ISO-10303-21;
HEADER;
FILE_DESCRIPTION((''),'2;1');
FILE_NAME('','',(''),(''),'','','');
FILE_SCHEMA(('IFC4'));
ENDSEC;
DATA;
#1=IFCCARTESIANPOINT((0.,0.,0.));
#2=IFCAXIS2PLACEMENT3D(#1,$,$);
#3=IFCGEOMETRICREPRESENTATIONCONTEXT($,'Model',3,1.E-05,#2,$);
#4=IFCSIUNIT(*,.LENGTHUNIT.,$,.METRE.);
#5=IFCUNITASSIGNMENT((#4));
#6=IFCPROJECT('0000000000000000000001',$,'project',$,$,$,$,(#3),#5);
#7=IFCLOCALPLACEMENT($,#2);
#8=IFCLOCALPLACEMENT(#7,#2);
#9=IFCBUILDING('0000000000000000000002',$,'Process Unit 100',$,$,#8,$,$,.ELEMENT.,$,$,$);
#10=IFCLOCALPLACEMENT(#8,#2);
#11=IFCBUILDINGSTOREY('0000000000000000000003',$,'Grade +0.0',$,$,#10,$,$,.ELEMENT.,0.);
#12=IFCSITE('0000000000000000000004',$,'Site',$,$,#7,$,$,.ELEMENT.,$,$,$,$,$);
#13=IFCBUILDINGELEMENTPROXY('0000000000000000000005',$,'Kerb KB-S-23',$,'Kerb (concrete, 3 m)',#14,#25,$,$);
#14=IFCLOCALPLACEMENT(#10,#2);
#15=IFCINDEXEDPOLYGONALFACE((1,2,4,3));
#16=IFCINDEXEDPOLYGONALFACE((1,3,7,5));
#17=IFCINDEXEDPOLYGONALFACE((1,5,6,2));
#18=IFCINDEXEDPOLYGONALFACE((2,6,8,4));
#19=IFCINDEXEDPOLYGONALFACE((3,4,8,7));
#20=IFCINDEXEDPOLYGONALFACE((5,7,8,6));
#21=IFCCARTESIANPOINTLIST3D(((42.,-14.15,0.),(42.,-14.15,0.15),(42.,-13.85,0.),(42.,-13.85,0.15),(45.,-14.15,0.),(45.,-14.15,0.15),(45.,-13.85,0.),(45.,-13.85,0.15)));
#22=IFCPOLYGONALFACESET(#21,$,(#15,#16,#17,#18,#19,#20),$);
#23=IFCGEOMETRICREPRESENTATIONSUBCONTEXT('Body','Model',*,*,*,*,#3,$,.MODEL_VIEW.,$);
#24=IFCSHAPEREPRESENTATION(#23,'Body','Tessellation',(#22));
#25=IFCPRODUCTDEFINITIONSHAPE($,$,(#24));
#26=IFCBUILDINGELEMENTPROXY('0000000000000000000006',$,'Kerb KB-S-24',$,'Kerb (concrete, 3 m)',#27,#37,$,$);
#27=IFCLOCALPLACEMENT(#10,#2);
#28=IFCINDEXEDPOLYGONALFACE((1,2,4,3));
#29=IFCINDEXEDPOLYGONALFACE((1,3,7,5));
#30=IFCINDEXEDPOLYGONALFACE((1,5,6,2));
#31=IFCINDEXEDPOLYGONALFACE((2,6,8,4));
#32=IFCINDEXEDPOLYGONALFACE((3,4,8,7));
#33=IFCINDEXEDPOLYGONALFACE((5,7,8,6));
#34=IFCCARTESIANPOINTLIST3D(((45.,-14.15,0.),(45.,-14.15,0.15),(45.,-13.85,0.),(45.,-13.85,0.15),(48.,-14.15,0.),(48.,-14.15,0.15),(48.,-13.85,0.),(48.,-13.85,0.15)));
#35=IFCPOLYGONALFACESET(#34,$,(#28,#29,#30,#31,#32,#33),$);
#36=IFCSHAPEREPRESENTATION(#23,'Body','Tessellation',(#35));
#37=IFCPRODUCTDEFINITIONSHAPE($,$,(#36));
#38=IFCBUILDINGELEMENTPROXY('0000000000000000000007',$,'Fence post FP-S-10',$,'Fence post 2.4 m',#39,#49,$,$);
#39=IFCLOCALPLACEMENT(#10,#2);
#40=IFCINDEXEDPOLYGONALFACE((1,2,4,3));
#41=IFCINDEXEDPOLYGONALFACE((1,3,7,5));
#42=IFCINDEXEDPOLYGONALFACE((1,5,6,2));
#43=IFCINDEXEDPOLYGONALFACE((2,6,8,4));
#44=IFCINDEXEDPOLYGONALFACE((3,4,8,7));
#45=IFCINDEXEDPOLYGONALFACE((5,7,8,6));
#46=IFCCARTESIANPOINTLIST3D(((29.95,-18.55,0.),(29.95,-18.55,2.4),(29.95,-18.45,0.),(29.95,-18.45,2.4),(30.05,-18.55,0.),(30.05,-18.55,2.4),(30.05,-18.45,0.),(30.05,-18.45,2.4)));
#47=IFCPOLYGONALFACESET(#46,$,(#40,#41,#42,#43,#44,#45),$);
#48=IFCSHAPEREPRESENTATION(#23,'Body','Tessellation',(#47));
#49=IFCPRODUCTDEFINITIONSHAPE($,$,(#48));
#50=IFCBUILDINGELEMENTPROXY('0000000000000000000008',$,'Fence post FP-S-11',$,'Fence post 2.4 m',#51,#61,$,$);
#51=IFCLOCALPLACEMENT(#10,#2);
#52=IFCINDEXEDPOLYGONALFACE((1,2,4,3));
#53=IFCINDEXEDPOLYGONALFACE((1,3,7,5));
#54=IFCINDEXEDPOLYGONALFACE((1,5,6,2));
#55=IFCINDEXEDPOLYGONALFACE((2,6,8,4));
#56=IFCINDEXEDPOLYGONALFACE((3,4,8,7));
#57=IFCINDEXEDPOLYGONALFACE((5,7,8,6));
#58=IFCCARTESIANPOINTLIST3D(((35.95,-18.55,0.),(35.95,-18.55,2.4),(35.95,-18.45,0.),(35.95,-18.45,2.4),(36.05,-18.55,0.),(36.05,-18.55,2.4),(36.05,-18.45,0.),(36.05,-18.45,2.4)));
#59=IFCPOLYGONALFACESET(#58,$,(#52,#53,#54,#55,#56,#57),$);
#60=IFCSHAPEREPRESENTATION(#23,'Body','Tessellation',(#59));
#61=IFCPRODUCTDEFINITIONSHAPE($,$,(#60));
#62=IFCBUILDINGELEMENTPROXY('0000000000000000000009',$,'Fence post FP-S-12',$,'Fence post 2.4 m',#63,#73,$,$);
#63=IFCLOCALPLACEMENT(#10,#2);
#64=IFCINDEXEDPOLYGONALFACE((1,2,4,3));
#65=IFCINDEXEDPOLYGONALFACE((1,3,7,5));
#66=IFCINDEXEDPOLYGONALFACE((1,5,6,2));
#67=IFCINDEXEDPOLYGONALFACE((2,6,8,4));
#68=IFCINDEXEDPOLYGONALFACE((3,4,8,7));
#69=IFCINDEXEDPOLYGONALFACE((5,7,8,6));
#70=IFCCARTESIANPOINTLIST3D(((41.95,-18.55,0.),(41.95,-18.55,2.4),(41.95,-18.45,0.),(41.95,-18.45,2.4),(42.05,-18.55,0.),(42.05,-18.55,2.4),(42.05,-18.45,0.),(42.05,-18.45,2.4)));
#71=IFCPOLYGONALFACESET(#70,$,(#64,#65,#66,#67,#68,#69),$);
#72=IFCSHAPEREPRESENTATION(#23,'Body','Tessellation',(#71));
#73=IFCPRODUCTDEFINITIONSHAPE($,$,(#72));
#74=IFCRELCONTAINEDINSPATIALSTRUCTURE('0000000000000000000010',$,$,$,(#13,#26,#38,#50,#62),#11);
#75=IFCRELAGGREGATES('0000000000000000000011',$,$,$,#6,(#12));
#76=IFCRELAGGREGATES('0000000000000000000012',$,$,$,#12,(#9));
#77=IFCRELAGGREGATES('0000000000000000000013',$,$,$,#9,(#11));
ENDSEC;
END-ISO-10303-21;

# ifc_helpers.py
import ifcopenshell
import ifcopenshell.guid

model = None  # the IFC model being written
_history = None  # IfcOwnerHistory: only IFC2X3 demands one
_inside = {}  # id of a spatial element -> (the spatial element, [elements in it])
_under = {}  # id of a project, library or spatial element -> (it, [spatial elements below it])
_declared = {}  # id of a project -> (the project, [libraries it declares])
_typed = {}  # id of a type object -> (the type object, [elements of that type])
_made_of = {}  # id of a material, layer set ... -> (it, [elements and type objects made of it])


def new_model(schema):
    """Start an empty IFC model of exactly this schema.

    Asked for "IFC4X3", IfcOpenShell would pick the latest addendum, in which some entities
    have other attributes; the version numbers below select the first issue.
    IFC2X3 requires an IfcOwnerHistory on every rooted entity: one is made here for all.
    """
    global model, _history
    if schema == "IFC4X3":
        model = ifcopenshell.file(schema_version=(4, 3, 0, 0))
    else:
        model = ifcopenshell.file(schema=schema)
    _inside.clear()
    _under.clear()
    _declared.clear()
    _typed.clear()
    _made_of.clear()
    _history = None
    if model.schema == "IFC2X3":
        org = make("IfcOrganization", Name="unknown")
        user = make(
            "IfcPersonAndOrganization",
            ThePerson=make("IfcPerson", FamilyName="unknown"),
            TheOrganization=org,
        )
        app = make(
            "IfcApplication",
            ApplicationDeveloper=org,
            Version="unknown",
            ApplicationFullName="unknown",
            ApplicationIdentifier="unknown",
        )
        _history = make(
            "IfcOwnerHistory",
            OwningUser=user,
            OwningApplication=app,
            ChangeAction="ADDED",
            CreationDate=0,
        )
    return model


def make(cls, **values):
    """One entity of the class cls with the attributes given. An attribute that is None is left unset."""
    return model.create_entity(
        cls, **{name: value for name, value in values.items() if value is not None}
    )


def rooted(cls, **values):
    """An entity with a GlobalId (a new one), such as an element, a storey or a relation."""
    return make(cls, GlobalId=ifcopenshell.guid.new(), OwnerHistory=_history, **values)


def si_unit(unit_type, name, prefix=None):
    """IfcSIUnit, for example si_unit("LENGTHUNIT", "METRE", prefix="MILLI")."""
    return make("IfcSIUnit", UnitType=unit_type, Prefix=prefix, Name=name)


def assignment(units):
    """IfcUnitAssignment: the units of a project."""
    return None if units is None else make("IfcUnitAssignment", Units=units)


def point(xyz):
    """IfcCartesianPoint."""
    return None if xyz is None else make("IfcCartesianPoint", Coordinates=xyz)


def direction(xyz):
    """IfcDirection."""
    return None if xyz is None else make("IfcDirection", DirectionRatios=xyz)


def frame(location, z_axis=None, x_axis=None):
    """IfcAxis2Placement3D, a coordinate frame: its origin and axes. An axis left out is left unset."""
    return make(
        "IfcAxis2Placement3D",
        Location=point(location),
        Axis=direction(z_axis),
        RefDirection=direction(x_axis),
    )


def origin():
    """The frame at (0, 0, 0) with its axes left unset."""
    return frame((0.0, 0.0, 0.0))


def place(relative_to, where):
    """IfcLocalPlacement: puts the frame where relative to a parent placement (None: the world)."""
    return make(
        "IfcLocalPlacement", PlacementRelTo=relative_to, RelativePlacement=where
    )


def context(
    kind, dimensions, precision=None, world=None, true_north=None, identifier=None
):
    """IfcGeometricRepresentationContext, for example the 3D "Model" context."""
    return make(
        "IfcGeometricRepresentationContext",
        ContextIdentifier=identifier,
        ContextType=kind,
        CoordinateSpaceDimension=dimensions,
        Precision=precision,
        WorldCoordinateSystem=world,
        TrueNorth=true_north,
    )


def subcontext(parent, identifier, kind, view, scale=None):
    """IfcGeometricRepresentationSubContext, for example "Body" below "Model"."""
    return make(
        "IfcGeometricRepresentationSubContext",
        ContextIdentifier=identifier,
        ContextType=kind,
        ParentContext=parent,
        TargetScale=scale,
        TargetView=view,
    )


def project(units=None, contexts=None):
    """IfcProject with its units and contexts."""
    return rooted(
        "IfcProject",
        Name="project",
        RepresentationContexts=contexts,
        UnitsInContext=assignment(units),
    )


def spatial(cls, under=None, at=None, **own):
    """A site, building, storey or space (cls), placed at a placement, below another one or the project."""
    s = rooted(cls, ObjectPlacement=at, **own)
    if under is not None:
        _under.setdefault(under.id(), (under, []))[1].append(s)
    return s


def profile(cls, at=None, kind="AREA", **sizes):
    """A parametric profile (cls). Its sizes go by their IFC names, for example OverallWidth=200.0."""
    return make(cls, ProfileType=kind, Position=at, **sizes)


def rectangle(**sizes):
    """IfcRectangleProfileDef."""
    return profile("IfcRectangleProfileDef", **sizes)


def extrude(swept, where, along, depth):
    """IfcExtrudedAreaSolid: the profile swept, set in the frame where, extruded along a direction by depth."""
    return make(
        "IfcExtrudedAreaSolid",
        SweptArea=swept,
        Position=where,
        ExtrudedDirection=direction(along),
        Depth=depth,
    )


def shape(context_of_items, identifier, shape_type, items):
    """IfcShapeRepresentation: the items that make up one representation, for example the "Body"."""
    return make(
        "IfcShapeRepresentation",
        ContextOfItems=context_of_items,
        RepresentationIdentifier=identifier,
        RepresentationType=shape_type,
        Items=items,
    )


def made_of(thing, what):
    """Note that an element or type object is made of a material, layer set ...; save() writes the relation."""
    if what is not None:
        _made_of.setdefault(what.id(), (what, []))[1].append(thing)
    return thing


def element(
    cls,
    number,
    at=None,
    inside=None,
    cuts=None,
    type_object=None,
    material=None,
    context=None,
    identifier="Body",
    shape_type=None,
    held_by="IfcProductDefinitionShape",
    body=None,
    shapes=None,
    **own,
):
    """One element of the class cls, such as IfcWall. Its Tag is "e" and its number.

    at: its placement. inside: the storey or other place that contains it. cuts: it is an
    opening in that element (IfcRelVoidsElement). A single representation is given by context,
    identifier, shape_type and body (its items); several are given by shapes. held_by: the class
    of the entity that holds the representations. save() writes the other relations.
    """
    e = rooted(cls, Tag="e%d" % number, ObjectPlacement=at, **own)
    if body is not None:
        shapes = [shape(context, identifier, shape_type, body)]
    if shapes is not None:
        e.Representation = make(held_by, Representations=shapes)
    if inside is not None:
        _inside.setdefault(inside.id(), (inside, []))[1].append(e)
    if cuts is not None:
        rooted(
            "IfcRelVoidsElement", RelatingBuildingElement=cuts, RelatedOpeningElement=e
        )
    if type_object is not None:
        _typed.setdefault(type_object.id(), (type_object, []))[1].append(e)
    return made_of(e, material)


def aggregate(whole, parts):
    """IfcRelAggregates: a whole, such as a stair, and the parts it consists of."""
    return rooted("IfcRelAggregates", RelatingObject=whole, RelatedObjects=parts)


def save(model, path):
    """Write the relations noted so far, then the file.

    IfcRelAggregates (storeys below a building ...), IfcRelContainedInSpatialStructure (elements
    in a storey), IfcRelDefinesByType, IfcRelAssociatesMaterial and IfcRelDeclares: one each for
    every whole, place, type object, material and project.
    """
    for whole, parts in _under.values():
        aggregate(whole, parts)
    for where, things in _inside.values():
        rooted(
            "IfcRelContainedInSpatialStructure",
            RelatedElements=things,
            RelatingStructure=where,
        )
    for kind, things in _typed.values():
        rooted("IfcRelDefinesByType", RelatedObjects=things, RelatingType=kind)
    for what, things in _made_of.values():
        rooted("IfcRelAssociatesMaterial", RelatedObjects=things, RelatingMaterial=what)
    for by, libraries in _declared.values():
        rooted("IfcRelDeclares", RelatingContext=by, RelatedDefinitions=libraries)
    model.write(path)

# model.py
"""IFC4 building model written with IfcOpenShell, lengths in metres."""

from ifc_helpers import new_model, si_unit, frame, origin, place, context, subcontext, project, spatial, rectangle, extrude, element, save


model = new_model("IFC4")

# Units and contexts
model_context = context("Model", 3, precision=1e-05, world=origin())
body_context = subcontext(model_context, "Body", "Model", "MODEL_VIEW")
ifc_project = project(units=[si_unit("LENGTHUNIT", "METRE")], contexts=[model_context])

# Site, building, storey
site_placement = place(None, origin())
site = spatial("IfcSite", under=ifc_project, at=site_placement, Name="Site", CompositionType="ELEMENT")
building_placement = place(site_placement, origin())
building = spatial("IfcBuilding", under=site, at=building_placement, Name="Process Unit 100", CompositionType="ELEMENT")
storey_placement = place(building_placement, origin())
storey = spatial("IfcBuildingStorey", under=building, at=storey_placement, Name="Grade +0.0", CompositionType="ELEMENT", Elevation=0.0)

# Building element proxies
for number, where, z_axis, x_axis, name in (
    (1, (43.5, -14.0, 0.0), (0.0, 0.0, 1.0), (1.0, 0.0, 0.0), "Kerb KB-S-23"),
    (2, (46.5, -14.0, 0.0), (0.0, 0.0, 1.0), (1.0, 0.0, 0.0), "Kerb KB-S-24"),
):
    element("IfcBuildingElementProxy", number, at=place(storey_placement, frame(where, z_axis=z_axis, x_axis=x_axis)), inside=storey, Name=name, ObjectType="Kerb (concrete, 3 m)", context=body_context, shape_type="SweptSolid", body=[
        extrude(rectangle(XDim=3.0, YDim=0.3), origin(), (0.0, 0.0, 1.0), 0.15),
    ])
for number, where, z_axis, x_axis, name in (
    (3, (30.0, -18.5, 0.0), (0.0, 0.0, 1.0), (1.0, 0.0, 0.0), "Fence post FP-S-10"),
    (4, (36.0, -18.5, 0.0), (0.0, 0.0, 1.0), (1.0, 0.0, 0.0), "Fence post FP-S-11"),
    (5, (42.0, -18.5, 0.0), (0.0, 0.0, 1.0), (1.0, 0.0, 0.0), "Fence post FP-S-12"),
):
    element("IfcBuildingElementProxy", number, at=place(storey_placement, frame(where, z_axis=z_axis, x_axis=x_axis)), inside=storey, Name=name, ObjectType="Fence post 2.4 m", context=body_context, shape_type="SweptSolid", body=[
        extrude(rectangle(XDim=0.1, YDim=0.1), origin(), (0.0, 0.0, 1.0), 2.4),
    ])

save(model, "model.ifc")
